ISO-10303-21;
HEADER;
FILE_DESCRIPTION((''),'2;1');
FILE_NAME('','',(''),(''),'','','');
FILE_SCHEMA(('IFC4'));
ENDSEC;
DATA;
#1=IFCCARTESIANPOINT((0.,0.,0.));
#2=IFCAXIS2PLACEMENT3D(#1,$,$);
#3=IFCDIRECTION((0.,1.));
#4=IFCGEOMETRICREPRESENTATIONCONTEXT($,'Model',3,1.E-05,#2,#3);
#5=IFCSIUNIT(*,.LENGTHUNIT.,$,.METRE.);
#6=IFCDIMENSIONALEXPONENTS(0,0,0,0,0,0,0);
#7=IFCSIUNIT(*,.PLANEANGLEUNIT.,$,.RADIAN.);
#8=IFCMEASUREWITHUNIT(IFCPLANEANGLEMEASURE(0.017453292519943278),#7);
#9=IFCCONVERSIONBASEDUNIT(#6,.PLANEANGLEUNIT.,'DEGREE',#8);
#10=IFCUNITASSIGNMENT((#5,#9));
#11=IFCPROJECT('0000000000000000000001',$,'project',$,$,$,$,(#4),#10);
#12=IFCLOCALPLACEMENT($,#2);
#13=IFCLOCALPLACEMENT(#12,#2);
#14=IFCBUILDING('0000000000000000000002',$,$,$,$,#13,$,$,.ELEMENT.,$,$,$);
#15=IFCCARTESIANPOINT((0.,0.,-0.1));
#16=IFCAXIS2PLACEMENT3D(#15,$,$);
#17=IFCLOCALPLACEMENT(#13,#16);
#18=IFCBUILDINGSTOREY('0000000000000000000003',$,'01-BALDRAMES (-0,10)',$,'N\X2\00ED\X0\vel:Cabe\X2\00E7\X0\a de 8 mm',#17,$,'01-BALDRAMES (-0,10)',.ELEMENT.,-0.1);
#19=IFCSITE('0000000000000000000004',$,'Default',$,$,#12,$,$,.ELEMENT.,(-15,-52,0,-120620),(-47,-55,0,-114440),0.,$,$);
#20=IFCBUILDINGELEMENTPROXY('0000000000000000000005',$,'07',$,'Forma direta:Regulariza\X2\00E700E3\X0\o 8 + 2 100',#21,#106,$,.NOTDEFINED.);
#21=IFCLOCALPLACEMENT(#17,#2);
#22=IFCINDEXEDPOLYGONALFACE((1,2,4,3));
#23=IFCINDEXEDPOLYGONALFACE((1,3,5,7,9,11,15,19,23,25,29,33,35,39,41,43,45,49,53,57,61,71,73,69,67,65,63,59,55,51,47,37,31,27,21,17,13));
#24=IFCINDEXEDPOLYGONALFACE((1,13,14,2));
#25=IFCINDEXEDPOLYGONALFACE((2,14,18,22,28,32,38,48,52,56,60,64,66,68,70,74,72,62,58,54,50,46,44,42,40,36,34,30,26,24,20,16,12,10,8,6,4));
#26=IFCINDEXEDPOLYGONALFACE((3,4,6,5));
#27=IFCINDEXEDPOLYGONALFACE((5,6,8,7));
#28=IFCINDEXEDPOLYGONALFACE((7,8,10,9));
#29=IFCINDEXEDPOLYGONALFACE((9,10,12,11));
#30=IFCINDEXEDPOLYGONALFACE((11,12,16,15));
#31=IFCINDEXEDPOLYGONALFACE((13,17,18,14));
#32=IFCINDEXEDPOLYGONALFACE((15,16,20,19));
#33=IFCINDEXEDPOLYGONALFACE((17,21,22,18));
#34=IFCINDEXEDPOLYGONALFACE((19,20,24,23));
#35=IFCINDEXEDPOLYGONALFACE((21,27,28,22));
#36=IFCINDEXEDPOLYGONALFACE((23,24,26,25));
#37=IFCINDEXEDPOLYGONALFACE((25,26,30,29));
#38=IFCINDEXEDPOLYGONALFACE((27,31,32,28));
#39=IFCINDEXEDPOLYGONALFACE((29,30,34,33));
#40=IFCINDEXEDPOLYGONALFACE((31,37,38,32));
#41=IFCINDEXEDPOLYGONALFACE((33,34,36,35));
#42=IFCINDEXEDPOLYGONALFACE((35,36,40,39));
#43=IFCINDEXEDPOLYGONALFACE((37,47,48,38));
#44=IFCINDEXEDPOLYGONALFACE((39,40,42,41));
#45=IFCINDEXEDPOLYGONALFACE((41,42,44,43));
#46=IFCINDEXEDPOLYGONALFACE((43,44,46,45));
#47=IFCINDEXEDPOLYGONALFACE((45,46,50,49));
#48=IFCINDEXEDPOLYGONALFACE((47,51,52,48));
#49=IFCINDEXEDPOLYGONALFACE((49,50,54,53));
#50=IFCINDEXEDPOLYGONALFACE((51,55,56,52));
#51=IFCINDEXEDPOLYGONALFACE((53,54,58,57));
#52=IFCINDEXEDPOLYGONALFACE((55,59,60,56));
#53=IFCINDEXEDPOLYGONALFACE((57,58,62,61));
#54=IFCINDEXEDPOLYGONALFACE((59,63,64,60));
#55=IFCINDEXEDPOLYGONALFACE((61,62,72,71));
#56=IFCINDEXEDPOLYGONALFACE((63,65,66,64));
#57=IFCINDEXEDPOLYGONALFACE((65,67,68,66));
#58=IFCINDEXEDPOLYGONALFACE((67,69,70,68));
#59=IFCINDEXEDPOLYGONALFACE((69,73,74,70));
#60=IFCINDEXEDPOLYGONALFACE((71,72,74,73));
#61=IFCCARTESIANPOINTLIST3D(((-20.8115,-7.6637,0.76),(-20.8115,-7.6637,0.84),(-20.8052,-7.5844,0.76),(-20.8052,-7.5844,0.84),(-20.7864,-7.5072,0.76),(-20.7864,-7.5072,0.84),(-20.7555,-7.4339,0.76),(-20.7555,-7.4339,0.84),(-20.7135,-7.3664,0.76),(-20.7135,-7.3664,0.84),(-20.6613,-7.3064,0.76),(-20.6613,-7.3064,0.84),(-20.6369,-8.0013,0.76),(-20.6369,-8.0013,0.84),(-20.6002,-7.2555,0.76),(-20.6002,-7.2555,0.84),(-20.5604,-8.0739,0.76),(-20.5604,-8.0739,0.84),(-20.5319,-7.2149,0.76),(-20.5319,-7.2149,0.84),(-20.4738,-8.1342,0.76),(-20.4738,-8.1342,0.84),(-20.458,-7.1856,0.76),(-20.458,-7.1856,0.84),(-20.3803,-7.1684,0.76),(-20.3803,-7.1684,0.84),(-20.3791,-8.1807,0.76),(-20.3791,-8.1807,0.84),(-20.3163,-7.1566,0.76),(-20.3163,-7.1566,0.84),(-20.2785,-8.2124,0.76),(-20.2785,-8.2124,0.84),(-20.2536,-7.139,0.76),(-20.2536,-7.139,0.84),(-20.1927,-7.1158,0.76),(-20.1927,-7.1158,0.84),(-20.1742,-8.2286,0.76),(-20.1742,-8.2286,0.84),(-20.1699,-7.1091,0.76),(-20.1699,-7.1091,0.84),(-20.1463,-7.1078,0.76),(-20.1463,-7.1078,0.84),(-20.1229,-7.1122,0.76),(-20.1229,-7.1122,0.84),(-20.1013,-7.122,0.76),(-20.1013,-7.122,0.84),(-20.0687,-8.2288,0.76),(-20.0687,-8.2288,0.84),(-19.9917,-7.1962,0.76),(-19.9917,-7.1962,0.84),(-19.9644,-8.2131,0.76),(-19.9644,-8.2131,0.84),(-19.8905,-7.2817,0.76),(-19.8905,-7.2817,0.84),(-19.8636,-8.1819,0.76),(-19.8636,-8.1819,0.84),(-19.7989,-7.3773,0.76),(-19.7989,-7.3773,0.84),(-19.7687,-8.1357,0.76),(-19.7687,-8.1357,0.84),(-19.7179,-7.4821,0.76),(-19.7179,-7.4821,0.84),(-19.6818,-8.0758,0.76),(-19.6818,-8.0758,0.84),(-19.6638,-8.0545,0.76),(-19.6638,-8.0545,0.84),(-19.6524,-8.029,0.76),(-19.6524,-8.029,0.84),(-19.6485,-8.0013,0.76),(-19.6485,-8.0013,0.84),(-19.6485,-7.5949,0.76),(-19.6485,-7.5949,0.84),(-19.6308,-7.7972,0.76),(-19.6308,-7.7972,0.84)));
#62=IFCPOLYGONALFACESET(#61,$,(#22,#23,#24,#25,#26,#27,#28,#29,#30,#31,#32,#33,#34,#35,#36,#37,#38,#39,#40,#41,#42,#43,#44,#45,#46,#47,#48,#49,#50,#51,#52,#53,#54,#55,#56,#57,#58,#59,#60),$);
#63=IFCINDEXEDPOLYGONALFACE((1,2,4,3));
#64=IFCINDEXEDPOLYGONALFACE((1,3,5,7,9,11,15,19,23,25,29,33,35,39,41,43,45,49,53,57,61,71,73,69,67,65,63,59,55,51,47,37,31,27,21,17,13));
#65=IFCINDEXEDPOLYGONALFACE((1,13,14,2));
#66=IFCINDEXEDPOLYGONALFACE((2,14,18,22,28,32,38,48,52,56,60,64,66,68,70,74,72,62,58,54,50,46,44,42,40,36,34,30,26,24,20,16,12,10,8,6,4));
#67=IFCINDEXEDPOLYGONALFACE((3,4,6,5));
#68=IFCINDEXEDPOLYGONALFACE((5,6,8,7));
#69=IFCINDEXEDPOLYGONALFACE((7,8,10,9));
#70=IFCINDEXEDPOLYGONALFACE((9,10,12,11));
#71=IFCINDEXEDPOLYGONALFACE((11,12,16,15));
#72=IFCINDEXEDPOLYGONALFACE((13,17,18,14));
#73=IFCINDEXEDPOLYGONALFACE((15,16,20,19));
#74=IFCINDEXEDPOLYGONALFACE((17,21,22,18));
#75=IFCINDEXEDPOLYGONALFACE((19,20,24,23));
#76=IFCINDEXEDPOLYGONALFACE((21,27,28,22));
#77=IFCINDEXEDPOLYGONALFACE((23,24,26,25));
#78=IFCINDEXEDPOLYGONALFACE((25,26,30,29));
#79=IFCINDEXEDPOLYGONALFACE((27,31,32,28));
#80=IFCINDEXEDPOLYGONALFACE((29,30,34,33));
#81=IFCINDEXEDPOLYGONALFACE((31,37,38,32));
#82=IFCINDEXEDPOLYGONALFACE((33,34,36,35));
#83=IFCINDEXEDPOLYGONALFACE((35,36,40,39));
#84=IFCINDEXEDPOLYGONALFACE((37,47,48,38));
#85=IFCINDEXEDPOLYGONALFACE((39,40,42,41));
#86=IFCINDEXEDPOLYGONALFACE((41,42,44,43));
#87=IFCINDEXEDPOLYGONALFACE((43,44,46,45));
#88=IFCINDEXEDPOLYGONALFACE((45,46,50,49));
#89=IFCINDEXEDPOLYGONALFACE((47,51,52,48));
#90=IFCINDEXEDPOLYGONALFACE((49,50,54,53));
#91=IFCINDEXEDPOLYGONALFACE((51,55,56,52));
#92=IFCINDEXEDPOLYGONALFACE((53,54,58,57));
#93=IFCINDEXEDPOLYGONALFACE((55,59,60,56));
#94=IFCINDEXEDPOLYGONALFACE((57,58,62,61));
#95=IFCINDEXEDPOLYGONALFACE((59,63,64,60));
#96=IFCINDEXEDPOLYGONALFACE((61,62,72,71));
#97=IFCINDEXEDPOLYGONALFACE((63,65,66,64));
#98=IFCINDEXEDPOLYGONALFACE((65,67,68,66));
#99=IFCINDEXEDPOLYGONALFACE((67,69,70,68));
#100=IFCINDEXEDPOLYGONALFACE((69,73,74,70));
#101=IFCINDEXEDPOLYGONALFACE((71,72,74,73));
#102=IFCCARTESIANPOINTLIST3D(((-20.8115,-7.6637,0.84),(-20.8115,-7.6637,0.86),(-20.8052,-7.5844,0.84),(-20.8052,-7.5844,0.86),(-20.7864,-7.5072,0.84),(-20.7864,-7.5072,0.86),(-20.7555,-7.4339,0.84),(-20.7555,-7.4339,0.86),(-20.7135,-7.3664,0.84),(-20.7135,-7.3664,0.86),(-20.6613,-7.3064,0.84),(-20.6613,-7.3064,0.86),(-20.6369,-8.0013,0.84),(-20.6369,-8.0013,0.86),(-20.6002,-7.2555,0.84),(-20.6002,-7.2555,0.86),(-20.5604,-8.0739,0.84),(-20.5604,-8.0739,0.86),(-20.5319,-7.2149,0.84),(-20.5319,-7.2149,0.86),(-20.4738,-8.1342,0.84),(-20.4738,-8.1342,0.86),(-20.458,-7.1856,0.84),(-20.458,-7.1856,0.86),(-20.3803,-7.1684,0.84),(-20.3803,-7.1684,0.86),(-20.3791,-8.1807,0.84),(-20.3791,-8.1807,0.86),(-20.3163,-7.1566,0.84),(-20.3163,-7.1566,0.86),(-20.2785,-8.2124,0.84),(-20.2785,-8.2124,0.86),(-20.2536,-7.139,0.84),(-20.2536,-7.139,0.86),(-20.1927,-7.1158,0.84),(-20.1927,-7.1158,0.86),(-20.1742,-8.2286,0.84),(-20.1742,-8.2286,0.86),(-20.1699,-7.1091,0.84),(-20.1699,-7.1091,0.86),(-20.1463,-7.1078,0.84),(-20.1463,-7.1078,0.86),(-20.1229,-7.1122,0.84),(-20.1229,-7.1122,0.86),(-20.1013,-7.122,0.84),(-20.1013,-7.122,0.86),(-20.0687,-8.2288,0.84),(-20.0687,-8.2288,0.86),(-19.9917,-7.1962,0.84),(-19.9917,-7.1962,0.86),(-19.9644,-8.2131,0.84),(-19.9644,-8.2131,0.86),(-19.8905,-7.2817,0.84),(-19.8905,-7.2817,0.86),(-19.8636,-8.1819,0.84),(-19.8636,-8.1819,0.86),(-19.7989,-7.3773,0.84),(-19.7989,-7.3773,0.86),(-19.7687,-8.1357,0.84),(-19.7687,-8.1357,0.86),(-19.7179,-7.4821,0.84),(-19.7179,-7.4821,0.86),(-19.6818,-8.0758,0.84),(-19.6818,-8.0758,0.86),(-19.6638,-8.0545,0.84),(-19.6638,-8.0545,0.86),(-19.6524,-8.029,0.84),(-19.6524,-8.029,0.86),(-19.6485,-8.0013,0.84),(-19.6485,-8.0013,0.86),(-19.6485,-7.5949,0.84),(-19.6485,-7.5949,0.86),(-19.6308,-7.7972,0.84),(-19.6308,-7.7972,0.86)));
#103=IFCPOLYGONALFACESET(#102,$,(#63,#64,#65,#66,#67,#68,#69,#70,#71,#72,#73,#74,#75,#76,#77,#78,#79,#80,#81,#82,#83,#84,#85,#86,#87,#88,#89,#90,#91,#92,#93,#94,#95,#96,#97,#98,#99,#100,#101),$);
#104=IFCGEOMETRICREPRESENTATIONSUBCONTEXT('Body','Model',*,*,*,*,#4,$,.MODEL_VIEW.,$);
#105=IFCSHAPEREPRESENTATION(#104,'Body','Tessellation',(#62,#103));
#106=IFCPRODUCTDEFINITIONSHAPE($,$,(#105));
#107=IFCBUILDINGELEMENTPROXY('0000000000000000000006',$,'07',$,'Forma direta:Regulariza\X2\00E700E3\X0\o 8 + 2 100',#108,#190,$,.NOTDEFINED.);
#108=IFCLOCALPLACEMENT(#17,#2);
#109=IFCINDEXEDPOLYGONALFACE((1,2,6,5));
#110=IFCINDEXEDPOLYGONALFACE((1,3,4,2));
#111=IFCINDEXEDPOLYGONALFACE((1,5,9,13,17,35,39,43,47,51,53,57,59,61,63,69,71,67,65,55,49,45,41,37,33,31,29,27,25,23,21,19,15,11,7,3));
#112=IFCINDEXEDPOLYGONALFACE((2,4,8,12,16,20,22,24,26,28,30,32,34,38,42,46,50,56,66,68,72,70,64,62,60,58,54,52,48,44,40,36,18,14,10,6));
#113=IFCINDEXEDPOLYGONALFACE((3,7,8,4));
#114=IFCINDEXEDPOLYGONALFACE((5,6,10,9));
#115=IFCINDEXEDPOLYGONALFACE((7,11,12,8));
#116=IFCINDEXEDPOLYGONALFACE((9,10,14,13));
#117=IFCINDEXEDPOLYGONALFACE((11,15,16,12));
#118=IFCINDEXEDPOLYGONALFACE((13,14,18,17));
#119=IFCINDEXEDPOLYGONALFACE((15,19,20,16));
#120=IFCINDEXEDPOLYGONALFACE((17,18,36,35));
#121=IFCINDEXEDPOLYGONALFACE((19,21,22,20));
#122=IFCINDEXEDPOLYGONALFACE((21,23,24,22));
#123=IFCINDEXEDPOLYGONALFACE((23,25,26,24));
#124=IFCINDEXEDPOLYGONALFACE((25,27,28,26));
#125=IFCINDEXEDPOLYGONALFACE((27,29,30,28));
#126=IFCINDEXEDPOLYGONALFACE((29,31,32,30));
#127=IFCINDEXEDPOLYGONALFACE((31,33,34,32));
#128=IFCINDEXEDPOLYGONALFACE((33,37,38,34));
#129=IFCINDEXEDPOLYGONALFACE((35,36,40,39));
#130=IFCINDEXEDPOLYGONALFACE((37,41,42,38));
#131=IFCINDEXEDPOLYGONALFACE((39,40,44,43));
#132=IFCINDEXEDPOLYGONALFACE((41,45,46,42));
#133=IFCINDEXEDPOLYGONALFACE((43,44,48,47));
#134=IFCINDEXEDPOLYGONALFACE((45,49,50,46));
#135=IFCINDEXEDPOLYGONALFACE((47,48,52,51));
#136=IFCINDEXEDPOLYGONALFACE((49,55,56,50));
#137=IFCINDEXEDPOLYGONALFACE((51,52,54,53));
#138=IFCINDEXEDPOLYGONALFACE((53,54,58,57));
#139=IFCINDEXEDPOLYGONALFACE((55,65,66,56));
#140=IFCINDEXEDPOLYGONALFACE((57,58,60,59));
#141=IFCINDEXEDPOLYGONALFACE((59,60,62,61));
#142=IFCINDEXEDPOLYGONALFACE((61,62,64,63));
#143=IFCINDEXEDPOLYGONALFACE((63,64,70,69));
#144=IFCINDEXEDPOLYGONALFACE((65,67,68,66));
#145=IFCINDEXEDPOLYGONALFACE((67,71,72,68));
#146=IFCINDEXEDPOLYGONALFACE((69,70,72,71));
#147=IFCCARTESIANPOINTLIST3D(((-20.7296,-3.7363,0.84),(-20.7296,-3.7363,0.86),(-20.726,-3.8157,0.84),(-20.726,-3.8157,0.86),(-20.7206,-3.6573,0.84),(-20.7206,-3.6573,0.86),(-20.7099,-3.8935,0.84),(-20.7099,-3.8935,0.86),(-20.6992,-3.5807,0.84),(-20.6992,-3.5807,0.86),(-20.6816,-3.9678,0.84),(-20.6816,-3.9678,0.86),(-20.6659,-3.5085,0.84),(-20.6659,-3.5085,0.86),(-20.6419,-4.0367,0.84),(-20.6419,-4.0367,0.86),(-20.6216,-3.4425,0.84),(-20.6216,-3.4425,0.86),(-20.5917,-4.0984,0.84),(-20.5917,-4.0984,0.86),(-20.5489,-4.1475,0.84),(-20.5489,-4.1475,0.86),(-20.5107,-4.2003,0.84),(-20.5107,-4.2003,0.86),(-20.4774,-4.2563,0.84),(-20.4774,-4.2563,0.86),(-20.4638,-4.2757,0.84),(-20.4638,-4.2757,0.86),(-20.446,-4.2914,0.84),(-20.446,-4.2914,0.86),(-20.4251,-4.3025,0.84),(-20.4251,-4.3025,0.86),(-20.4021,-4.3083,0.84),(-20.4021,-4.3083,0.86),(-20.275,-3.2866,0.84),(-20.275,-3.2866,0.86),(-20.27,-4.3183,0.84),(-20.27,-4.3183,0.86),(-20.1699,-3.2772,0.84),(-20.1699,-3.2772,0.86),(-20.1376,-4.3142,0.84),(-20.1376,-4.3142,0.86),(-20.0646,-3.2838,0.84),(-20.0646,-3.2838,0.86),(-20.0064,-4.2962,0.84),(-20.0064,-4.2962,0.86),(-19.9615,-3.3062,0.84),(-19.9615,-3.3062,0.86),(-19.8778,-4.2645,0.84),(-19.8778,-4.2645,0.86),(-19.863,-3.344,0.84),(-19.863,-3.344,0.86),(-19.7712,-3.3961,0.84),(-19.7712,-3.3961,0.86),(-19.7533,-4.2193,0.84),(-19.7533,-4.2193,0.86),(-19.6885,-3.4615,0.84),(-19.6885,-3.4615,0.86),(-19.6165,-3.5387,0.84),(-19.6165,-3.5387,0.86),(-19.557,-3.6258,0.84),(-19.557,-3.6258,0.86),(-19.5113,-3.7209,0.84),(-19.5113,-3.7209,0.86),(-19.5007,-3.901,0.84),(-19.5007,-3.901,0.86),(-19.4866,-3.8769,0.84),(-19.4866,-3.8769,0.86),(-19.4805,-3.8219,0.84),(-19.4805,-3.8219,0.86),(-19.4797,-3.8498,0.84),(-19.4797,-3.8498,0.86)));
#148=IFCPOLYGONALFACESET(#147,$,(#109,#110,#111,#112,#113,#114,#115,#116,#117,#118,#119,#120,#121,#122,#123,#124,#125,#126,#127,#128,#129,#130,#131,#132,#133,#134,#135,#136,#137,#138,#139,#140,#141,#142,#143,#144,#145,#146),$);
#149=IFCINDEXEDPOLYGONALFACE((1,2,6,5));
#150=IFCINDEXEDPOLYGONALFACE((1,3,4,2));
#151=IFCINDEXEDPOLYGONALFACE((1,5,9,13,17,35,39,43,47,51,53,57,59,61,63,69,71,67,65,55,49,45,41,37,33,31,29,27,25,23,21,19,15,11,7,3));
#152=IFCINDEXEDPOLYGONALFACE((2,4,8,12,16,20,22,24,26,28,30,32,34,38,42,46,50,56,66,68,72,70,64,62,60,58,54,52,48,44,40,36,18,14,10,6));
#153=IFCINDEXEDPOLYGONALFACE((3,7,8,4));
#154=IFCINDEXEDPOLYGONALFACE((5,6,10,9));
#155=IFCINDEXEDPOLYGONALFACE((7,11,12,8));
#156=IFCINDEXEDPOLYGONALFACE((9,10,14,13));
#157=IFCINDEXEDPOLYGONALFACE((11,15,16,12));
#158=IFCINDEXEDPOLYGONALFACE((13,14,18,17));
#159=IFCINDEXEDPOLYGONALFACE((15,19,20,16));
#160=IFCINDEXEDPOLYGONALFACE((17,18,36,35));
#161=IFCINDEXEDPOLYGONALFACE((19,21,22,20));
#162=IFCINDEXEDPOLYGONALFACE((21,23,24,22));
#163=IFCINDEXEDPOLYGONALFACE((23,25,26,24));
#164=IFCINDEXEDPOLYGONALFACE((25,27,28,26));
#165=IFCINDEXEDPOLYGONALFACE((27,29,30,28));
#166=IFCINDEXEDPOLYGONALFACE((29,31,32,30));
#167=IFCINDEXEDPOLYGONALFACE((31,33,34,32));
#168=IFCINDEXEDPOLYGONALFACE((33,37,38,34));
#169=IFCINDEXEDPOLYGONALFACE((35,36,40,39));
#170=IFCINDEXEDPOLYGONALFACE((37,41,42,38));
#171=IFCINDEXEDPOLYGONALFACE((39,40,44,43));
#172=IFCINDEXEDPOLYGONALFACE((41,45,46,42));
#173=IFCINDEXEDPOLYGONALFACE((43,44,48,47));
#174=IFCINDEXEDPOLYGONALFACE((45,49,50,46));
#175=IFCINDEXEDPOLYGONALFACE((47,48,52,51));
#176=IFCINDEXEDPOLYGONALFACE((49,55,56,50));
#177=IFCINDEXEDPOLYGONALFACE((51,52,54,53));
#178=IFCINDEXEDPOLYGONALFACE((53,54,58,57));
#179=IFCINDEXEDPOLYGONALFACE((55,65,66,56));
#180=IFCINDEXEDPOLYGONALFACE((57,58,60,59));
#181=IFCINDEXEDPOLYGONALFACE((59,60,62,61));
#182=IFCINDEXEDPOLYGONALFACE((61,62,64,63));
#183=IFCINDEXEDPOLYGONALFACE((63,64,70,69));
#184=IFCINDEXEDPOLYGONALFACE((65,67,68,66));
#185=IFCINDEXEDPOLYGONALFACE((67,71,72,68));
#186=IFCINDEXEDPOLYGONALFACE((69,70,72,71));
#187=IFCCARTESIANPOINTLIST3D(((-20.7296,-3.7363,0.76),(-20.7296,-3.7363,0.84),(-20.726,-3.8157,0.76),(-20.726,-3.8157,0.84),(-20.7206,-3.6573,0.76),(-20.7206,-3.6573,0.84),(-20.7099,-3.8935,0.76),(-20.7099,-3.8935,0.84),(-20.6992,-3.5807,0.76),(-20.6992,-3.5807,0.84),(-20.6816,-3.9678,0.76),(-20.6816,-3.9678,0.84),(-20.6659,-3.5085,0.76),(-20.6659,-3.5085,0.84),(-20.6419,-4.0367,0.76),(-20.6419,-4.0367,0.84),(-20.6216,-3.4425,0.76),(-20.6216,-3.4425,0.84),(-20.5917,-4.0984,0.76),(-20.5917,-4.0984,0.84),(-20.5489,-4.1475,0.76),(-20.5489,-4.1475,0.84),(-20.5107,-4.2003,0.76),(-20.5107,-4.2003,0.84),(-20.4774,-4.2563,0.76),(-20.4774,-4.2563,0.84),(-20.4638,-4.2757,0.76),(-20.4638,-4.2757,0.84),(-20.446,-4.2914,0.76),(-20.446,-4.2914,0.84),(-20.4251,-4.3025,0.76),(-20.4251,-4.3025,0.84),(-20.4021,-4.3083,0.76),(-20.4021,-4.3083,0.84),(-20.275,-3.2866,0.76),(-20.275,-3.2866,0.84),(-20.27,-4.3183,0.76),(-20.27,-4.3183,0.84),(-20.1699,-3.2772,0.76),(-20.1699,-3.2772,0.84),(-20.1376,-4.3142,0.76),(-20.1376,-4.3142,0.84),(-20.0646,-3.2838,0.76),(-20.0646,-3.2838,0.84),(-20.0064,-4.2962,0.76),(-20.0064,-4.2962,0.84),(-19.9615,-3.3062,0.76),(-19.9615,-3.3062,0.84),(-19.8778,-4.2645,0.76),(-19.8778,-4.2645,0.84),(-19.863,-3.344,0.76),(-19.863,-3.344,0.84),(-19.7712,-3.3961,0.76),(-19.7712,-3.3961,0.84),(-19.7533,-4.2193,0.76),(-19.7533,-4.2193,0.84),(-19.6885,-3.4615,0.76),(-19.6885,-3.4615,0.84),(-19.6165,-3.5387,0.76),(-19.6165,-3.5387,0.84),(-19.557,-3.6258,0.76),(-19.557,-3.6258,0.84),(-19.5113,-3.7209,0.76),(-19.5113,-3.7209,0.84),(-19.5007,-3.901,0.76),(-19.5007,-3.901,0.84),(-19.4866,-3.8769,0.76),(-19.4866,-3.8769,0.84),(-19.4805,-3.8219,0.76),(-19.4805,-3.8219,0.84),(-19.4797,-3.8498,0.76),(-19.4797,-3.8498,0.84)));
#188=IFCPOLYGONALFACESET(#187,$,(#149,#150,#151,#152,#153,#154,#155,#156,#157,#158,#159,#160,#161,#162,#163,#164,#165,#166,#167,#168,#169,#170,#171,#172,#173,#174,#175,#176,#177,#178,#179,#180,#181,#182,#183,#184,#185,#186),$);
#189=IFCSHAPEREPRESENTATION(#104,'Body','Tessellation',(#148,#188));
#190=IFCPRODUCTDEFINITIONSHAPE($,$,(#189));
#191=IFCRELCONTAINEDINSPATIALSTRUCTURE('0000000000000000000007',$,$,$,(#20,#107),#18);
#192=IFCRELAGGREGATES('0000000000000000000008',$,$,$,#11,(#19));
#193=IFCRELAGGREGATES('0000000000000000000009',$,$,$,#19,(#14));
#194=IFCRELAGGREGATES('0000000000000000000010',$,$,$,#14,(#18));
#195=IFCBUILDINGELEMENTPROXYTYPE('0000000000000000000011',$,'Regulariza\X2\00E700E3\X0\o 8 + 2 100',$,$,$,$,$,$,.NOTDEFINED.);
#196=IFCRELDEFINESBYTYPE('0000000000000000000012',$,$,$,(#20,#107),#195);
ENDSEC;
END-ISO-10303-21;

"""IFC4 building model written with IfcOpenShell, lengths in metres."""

from ifc_helpers import new_model, entity, si_unit, converted_unit, direction, frame, origin, place, context, subcontext, project, spatial, line, arc, indexed_curve, outline, extrude, type_object, element, save


model = new_model("IFC4")

# Units and contexts
model_context = context("Model", 3, precision=1e-05, world=origin(), true_north=direction((0.0, 1.0)))
body_context = subcontext(model_context, "Body", "Model", "MODEL_VIEW")
ifc_project = project(units=[si_unit("LENGTHUNIT", "METRE"), converted_unit("PLANEANGLEUNIT", "DEGREE", entity("IfcPlaneAngleMeasure", 0.017453292519943278), si_unit("PLANEANGLEUNIT", "RADIAN"), dimensions=[0, 0, 0, 0, 0, 0, 0])], contexts=[model_context])

# Site, building, storey
site_placement = place(None, origin())
site = spatial("IfcSite", under=ifc_project, at=site_placement, Name="Default", CompositionType="ELEMENT", RefLatitude=(-15, -52, 0, -120620), RefLongitude=(-47, -55, 0, -114440), RefElevation=0.0)
building_placement = place(site_placement, origin())
building = spatial("IfcBuilding", under=site, at=building_placement, CompositionType="ELEMENT")
storey_placement = place(building_placement, frame((0.0, 0.0, -0.1)))
storey = spatial("IfcBuildingStorey", under=building, at=storey_placement, Name="01-BALDRAMES (-0,10)", ObjectType="Nível:Cabeça de 8 mm", LongName="01-BALDRAMES (-0,10)", CompositionType="ELEMENT", Elevation=-0.1)

# Building element proxies
building_element_proxy_type_1 = type_object("IfcBuildingElementProxyType", Name="Regularização 8 + 2 100", PredefinedType="NOTDEFINED")
proxy_1_placement = place(storey_placement, origin())
element("IfcBuildingElementProxy", 1, at=proxy_1_placement, inside=storey, type_object=building_element_proxy_type_1, Name="07", ObjectType="Forma direta:Regularização 8 + 2 100", PredefinedType="NOTDEFINED", context=body_context, shape_type="SweptSolid", body=[
    extrude(outline(indexed_curve([(0.6094, -0.0089), (0.6007, 0.0319), (0.576, 0.0656), (0.4357, 0.2148), (0.2731, 0.3365), (-0.0556, 0.3689), (-0.3813, 0.3142), (-0.4218, 0.2901), (-0.4467, 0.2502), (-0.4838, 0.1598), (-0.5326, 0.0752), (-0.6136, -0.2659), (-0.4508, -0.5763), (-0.0828, -0.6712), (0.3951, -0.4778)], segments=[arc(1, 2, 3), line(3, 4, 5), arc(5, 6, 7), arc(7, 8, 9), arc(9, 10, 11), arc(11, 12, 13), line(13, 14), arc(14, 15, 1)], self_intersect=False)), frame((-20.0814, -7.6156, 0.76), z_axis=(0.0, 0.0, 1.0), x_axis=(0.66655, -0.74546, 0.0)), (0.0, 0.0, 1.0), 0.08),
    extrude(outline(indexed_curve([(0.6094, -0.0089), (0.6007, 0.0319), (0.576, 0.0656), (0.4357, 0.2148), (0.2731, 0.3365), (-0.0556, 0.3689), (-0.3813, 0.3142), (-0.4218, 0.2901), (-0.4467, 0.2502), (-0.4838, 0.1598), (-0.5326, 0.0752), (-0.6136, -0.2659), (-0.4508, -0.5763), (-0.0828, -0.6712), (0.3951, -0.4778)], segments=[arc(1, 2, 3), line(3, 4, 5), arc(5, 6, 7), arc(7, 8, 9), arc(9, 10, 11), arc(11, 12, 13), line(13, 14), arc(14, 15, 1)], self_intersect=False)), frame((-20.0814, -7.6156, 0.84), z_axis=(0.0, 0.0, 1.0), x_axis=(0.66655, -0.74546, 0.0)), (0.0, 0.0, 1.0), 0.02),
])
proxy_2_placement = place(storey_placement, origin())
element("IfcBuildingElementProxy", 2, at=proxy_2_placement, inside=storey, type_object=building_element_proxy_type_1, Name="07", ObjectType="Forma direta:Regularização 8 + 2 100", PredefinedType="NOTDEFINED", context=body_context, shape_type="SweptSolid", body=[
    extrude(outline(indexed_curve([(0.6738, -0.0708), (0.5509, 0.2575), (0.2427, 0.4245), (0.147, 0.4444), (0.055, 0.4771), (0.0086, 0.4851), (-0.0364, 0.4709), (-0.2943, 0.2646), (-0.4892, -0.002), (-0.4892, -0.4084), (-0.4805, -0.4492), (-0.4559, -0.4829), (0.0365, -0.6357), (0.4992, -0.4084)], segments=[arc(1, 2, 3), arc(3, 4, 5), arc(5, 6, 7), arc(7, 8, 9), line(9, 10), arc(10, 11, 12), arc(12, 13, 14), line(14, 1)], self_intersect=False)), frame((-20.1378, -3.9168, 0.84), z_axis=(0.0, 0.0, 1.0), x_axis=(-0.78332, 0.621618, 0.0)), (0.0, 0.0, 1.0), 0.02),
    extrude(outline(indexed_curve([(0.6738, -0.0708), (0.5509, 0.2575), (0.2427, 0.4245), (0.147, 0.4444), (0.055, 0.4771), (0.0086, 0.4851), (-0.0364, 0.4709), (-0.2943, 0.2646), (-0.4892, -0.002), (-0.4892, -0.4084), (-0.4805, -0.4492), (-0.4559, -0.4829), (0.0365, -0.6357), (0.4992, -0.4084)], segments=[arc(1, 2, 3), arc(3, 4, 5), arc(5, 6, 7), arc(7, 8, 9), line(9, 10), arc(10, 11, 12), arc(12, 13, 14), line(14, 1)], self_intersect=False)), frame((-20.1378, -3.9168, 0.76), z_axis=(0.0, 0.0, 1.0), x_axis=(-0.78332, 0.621618, 0.0)), (0.0, 0.0, 1.0), 0.08),
])

save(model, "model.ifc")
